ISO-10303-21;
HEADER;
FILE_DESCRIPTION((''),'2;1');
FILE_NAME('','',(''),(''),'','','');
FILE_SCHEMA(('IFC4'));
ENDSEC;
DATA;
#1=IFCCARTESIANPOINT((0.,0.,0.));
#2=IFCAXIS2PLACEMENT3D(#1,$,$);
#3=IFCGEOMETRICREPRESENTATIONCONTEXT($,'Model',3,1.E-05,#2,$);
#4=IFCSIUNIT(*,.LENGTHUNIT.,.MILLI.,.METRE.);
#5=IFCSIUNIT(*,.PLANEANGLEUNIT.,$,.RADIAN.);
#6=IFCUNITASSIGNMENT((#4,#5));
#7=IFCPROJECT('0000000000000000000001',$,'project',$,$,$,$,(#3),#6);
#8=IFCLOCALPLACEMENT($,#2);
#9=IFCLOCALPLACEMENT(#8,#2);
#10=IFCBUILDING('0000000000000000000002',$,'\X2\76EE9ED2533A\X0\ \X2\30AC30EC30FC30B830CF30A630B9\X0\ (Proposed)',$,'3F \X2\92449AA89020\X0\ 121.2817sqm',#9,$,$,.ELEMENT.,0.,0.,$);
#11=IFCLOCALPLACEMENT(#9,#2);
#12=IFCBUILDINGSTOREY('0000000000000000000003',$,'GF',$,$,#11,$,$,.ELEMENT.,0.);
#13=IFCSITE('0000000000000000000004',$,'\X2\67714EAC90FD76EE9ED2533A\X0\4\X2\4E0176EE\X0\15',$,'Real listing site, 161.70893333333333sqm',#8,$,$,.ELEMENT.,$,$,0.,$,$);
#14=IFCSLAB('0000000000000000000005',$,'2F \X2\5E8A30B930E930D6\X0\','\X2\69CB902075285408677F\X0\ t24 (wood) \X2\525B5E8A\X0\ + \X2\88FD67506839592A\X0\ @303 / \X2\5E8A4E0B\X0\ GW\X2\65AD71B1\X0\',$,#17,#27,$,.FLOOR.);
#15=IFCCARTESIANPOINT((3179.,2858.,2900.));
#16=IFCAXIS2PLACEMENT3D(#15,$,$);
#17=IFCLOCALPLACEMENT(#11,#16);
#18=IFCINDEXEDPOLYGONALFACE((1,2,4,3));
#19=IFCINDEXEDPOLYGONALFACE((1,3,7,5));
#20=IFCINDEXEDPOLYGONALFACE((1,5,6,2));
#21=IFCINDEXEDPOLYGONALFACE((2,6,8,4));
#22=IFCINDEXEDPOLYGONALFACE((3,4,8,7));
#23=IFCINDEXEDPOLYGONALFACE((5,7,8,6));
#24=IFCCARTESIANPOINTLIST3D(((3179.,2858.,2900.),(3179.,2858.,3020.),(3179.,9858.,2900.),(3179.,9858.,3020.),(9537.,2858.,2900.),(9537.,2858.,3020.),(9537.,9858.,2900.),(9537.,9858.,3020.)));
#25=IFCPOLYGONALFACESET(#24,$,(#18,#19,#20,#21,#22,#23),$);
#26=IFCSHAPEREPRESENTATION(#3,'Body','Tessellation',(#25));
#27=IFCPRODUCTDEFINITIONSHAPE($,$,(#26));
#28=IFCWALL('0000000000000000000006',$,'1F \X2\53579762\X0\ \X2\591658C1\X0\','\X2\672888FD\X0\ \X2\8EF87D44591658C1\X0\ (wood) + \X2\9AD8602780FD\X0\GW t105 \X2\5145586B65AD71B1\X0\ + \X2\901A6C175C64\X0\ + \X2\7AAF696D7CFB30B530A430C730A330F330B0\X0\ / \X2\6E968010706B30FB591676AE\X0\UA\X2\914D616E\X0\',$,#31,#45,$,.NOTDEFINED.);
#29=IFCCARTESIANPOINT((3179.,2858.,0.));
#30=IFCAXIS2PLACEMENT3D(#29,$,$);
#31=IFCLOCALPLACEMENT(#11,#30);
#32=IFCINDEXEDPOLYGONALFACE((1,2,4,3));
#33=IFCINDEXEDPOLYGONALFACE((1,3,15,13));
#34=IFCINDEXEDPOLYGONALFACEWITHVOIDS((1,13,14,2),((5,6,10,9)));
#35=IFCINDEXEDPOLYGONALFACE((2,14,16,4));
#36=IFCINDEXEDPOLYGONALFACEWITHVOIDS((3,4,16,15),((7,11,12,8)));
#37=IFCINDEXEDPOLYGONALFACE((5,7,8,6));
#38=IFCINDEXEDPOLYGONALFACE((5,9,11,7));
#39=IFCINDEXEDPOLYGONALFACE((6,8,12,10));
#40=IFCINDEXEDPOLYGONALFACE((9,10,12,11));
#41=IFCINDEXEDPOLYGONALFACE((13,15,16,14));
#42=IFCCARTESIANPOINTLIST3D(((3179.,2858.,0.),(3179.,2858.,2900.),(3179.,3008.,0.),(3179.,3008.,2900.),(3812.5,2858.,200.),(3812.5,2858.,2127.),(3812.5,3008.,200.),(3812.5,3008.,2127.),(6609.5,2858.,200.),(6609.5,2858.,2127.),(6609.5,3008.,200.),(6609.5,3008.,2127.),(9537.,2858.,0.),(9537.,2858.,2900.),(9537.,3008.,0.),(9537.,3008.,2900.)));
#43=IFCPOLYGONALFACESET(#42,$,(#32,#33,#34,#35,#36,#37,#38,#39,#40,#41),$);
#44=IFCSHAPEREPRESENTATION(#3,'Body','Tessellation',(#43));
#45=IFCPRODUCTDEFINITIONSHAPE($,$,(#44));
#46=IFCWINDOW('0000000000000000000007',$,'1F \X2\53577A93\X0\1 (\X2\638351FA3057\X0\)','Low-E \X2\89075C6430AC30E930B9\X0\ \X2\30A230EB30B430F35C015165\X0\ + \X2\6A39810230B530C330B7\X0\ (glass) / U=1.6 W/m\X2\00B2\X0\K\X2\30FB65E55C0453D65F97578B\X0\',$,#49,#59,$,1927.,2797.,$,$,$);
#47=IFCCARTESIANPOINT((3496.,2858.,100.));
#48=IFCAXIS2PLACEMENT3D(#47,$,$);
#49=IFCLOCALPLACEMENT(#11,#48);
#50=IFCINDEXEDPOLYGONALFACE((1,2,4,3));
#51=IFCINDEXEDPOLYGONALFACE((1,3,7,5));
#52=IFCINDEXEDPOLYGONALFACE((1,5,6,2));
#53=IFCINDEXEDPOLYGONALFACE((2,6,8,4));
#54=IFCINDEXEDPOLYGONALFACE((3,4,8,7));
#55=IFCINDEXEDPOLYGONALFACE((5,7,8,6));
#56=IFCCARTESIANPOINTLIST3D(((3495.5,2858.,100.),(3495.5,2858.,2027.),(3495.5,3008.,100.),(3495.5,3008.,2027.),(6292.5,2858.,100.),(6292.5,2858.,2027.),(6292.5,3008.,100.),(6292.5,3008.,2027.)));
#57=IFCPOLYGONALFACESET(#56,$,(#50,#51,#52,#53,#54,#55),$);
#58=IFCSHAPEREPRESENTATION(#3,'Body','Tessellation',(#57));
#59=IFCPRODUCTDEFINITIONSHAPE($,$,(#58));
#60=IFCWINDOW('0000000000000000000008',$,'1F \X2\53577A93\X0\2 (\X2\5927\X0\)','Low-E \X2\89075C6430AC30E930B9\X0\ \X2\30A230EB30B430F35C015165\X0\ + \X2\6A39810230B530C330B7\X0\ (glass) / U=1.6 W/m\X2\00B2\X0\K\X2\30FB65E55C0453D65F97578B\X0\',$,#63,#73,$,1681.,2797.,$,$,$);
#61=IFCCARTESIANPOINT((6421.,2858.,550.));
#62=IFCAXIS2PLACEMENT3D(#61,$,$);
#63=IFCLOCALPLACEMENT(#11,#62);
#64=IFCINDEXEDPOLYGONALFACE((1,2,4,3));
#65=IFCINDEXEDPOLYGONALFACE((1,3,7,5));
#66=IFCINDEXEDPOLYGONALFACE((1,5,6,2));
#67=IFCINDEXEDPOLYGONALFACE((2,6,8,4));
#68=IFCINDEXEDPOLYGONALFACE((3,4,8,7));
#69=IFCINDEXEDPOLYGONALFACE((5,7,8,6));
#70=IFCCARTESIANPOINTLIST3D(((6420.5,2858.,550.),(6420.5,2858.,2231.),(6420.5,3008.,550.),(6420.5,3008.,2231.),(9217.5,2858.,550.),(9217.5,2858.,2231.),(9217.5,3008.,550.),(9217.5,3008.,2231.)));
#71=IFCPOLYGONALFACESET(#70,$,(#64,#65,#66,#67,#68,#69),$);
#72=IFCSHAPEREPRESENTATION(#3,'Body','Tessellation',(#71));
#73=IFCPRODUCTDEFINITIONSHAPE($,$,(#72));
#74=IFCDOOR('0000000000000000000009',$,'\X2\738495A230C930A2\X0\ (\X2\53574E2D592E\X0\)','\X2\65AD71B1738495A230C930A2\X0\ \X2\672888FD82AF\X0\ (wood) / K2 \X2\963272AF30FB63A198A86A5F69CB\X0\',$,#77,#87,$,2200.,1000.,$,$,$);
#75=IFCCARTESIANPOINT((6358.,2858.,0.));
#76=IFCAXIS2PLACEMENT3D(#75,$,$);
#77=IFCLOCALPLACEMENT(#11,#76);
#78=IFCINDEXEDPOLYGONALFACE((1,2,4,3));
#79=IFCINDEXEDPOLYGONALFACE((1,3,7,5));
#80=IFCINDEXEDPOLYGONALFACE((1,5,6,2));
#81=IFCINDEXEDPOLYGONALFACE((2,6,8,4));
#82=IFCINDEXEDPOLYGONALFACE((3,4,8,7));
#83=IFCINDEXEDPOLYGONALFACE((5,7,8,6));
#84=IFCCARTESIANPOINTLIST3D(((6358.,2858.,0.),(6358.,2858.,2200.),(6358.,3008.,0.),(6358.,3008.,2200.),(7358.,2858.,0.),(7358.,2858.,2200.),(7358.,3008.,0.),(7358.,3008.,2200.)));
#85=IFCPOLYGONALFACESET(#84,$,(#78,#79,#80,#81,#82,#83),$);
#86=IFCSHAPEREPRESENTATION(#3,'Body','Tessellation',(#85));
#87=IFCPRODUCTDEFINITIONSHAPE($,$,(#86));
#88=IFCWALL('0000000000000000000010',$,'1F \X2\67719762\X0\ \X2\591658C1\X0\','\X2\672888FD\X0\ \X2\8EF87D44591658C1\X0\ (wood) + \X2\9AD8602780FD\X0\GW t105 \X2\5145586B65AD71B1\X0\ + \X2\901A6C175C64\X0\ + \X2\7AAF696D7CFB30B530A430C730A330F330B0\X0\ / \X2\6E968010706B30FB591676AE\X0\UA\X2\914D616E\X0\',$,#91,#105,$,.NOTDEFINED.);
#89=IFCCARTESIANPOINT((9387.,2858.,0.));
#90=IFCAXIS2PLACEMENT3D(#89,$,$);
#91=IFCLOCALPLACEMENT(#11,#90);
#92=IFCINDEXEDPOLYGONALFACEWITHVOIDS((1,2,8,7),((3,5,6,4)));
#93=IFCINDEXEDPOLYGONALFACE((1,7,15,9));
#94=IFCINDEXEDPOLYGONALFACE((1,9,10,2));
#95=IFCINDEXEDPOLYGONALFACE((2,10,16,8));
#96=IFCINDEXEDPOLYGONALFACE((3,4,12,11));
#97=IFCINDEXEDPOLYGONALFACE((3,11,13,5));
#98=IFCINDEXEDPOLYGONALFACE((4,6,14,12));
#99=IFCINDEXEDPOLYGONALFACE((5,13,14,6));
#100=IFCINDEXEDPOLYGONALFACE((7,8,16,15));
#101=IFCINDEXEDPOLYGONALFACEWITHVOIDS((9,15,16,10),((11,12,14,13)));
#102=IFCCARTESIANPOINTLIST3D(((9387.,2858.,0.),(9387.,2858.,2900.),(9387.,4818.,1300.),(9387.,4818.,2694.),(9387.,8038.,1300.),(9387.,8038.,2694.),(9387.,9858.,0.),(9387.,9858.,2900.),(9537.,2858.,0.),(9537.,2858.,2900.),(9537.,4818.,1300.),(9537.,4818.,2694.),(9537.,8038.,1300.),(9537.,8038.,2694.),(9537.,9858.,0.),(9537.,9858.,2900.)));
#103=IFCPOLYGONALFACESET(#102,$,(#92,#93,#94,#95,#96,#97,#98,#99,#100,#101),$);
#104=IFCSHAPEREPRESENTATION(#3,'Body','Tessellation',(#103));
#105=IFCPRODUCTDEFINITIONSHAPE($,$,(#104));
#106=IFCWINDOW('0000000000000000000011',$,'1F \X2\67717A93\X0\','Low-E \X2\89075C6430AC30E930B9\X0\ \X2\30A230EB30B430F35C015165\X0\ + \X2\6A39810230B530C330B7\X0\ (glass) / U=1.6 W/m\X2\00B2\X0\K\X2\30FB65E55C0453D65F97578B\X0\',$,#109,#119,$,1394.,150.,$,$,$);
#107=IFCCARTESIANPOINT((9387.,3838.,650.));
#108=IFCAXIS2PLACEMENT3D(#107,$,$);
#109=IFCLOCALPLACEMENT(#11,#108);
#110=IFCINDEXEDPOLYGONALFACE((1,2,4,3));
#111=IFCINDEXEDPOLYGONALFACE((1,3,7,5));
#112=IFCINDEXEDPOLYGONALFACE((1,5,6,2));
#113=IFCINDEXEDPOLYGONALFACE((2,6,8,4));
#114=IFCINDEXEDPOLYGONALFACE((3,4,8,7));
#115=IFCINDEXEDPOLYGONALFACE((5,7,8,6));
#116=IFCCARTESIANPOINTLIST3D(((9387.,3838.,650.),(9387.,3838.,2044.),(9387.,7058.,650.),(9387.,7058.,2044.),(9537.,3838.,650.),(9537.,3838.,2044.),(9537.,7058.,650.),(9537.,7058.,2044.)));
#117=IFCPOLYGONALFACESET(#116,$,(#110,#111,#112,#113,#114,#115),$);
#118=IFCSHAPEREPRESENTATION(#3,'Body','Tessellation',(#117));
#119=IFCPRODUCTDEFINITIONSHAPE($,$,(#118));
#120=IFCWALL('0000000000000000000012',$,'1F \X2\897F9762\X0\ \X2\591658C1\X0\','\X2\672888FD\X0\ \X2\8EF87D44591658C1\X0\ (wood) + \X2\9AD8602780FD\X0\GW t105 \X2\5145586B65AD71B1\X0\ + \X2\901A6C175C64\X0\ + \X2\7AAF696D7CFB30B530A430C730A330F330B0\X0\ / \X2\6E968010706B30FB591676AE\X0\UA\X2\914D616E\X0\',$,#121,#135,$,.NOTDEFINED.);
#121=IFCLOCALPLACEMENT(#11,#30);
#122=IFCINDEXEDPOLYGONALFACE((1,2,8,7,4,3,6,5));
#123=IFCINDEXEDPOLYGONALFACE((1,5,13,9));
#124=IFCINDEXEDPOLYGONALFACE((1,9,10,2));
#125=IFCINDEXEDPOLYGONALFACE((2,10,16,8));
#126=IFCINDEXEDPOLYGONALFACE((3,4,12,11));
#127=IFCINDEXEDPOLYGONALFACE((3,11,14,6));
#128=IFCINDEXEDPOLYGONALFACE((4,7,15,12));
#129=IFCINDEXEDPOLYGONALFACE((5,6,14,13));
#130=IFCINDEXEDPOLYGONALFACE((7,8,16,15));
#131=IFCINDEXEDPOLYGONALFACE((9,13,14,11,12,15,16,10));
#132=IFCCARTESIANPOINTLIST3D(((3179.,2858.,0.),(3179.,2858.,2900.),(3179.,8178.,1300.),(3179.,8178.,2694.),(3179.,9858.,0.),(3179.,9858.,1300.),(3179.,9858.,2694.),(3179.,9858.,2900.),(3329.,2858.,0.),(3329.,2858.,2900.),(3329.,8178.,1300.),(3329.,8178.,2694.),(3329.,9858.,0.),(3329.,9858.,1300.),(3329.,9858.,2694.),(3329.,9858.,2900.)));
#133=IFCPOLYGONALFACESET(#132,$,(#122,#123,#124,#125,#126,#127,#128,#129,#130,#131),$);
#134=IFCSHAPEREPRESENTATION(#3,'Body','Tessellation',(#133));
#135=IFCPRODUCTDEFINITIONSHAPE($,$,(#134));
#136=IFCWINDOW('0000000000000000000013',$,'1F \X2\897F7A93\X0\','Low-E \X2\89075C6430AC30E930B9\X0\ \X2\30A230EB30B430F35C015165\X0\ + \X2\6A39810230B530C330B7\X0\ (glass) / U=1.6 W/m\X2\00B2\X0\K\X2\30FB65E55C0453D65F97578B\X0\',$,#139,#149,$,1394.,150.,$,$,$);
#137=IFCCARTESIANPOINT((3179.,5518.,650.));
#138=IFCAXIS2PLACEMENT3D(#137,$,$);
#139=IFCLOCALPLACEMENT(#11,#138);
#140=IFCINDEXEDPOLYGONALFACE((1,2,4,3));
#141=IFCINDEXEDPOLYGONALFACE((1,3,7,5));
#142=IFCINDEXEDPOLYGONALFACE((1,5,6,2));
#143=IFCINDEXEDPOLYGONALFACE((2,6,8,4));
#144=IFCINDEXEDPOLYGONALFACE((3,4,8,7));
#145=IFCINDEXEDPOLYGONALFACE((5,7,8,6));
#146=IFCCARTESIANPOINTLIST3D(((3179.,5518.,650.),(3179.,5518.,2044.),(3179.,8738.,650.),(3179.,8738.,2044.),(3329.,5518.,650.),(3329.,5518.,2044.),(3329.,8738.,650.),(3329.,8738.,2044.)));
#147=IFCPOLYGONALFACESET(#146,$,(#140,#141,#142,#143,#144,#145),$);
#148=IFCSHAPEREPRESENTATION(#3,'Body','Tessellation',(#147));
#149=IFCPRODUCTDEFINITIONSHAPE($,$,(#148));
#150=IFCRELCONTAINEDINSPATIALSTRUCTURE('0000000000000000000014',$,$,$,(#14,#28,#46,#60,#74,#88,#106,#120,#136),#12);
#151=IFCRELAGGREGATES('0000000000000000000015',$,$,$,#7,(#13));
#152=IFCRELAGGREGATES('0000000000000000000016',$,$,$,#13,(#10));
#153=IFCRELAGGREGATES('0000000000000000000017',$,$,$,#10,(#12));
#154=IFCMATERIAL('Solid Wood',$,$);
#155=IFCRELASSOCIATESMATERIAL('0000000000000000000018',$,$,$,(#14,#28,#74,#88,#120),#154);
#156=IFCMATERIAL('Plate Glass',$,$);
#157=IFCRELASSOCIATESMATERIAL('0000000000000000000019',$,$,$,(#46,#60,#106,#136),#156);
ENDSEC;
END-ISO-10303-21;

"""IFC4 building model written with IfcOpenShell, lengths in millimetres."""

from ifc_helpers import new_model, si_unit, frame, frame_2d, origin, place, context, project, spatial, rectangle, extrude, material, element, fill, save


model = new_model("IFC4")

# Units and contexts
model_context = context("Model", 3, precision=1e-05, world=origin())
ifc_project = project(units=[si_unit("LENGTHUNIT", "METRE", prefix="MILLI"), si_unit("PLANEANGLEUNIT", "RADIAN")], contexts=[model_context])

# Site, building, storey
site_placement = place(None, origin())
site = spatial("IfcSite", under=ifc_project, at=site_placement, Name="東京都目黒区4丁目15", ObjectType="Real listing site, 161.70893333333333sqm", CompositionType="ELEMENT", RefElevation=0.0)
building_placement = place(site_placement, origin())
building = spatial("IfcBuilding", under=site, at=building_placement, Name="目黒区 ガレージハウス (Proposed)", ObjectType="3F 鉄骨造 121.2817sqm", CompositionType="ELEMENT", ElevationOfRefHeight=0.0, ElevationOfTerrain=0.0)
storey_placement = place(building_placement, origin())
storey = spatial("IfcBuildingStorey", under=building, at=storey_placement, Name="GF", CompositionType="ELEMENT", Elevation=0.0)

# Slab
ifc_material_1 = material(Name="Solid Wood")
slab_1_placement = place(storey_placement, frame((3179.0, 2858.0, 2900.0)))
element("IfcSlab", 1, at=slab_1_placement, inside=storey, material=ifc_material_1, Name="2F 床スラブ", Description="構造用合板 t24 (wood) 剛床 + 製材根太 @303 / 床下 GW断熱", PredefinedType="FLOOR", context=model_context, shape_type="SweptSolid", body=[
    extrude(rectangle(XDim=6358.0, YDim=7000.0, at=frame_2d((3179.0, 3500.0))), frame((3179.0, 2858.0, 2900.0)), (0.0, 0.0, 1.0), 120.0),
])

# Wall, openings, windows, door
wall_1_placement = place(storey_placement, frame((3179.0, 2858.0, 0.0)))
wall_1 = element("IfcWall", 2, at=wall_1_placement, inside=storey, material=ifc_material_1, Name="1F 南面 外壁", Description="木製 軸組外壁 (wood) + 高性能GW t105 充填断熱 + 通気層 + 窯業系サイディング / 準耐火・外皮UA配慮", PredefinedType="NOTDEFINED", context=model_context, shape_type="SweptSolid", body=[
    extrude(rectangle(XDim=6358.0, YDim=150.0, at=frame_2d((3179.0, 75.0))), frame((3179.0, 2858.0, 0.0)), (0.0, 0.0, 1.0), 2900.0),
])
opening_1_placement = place(storey_placement, frame((3496.0, 2858.0, 100.0)))
opening_1 = element("IfcOpeningElement", 3, at=opening_1_placement, cuts=wall_1, PredefinedType="NOTDEFINED", context=model_context, shape_type="SweptSolid", body=[
    extrude(rectangle(XDim=2797.0, YDim=150.0, at=frame_2d((1398.0, 75.0))), frame((3496.0, 2858.0, 100.0)), (0.0, 0.0, 1.0), 1927.0),
])
opening_2_placement = place(storey_placement, frame((6421.0, 2858.0, 550.0)))
opening_2 = element("IfcOpeningElement", 4, at=opening_2_placement, cuts=wall_1, PredefinedType="NOTDEFINED", context=model_context, shape_type="SweptSolid", body=[
    extrude(rectangle(XDim=2797.0, YDim=150.0, at=frame_2d((1398.0, 75.0))), frame((6421.0, 2858.0, 550.0)), (0.0, 0.0, 1.0), 1681.0),
])
opening_3_placement = place(storey_placement, frame((6358.0, 2858.0, 0.0)))
opening_3 = element("IfcOpeningElement", 5, at=opening_3_placement, cuts=wall_1, PredefinedType="NOTDEFINED", context=model_context, shape_type="SweptSolid", body=[
    extrude(rectangle(XDim=1000.0, YDim=150.0, at=frame_2d((500.0, 75.0))), frame((6358.0, 2858.0, 0.0)), (0.0, 0.0, 1.0), 2200.0),
])
ifc_material_2 = material(Name="Plate Glass")
window_1_placement = place(storey_placement, frame((3496.0, 2858.0, 100.0)))
window_1 = element("IfcWindow", 6, at=window_1_placement, inside=storey, material=ifc_material_2, Name="1F 南窓1 (掃出し)", Description="Low-E 複層ガラス アルゴン封入 + 樹脂サッシ (glass) / U=1.6 W/m²K・日射取得型", OverallHeight=1927.0, OverallWidth=2797.0, context=model_context, shape_type="SweptSolid", body=[
    extrude(rectangle(XDim=2797.0, YDim=150.0, at=frame_2d((1398.0, 75.0))), frame((3496.0, 2858.0, 100.0)), (0.0, 0.0, 1.0), 1927.0),
])
fill(opening_1, window_1)
window_2_placement = place(storey_placement, frame((6421.0, 2858.0, 550.0)))
window_2 = element("IfcWindow", 7, at=window_2_placement, inside=storey, material=ifc_material_2, Name="1F 南窓2 (大)", Description="Low-E 複層ガラス アルゴン封入 + 樹脂サッシ (glass) / U=1.6 W/m²K・日射取得型", OverallHeight=1681.0, OverallWidth=2797.0, context=model_context, shape_type="SweptSolid", body=[
    extrude(rectangle(XDim=2797.0, YDim=150.0, at=frame_2d((1398.0, 75.0))), frame((6421.0, 2858.0, 550.0)), (0.0, 0.0, 1.0), 1681.0),
])
fill(opening_2, window_2)
door_placement = place(storey_placement, frame((6358.0, 2858.0, 0.0)))
door = element("IfcDoor", 8, at=door_placement, inside=storey, material=ifc_material_1, Name="玄関ドア (南中央)", Description="断熱玄関ドア 木製芯 (wood) / K2 防犯・採風機構", OverallHeight=2200.0, OverallWidth=1000.0, context=model_context, shape_type="SweptSolid", body=[
    extrude(rectangle(XDim=1000.0, YDim=150.0, at=frame_2d((500.0, 75.0))), frame((6358.0, 2858.0, 0.0)), (0.0, 0.0, 1.0), 2200.0),
])
fill(opening_3, door)

# Walls, openings, windows
wall_2_placement = place(storey_placement, frame((9387.0, 2858.0, 0.0)))
wall_2 = element("IfcWall", 9, at=wall_2_placement, inside=storey, material=ifc_material_1, Name="1F 東面 外壁", Description="木製 軸組外壁 (wood) + 高性能GW t105 充填断熱 + 通気層 + 窯業系サイディング / 準耐火・外皮UA配慮", PredefinedType="NOTDEFINED", context=model_context, shape_type="SweptSolid", body=[
    extrude(rectangle(XDim=150.0, YDim=7000.0, at=frame_2d((75.0, 3500.0))), frame((9387.0, 2858.0, 0.0)), (0.0, 0.0, 1.0), 2900.0),
])
opening_4_placement = place(storey_placement, frame((9387.0, 3838.0, 650.0)))
opening_4 = element("IfcOpeningElement", 10, at=opening_4_placement, cuts=wall_2, PredefinedType="NOTDEFINED", context=model_context, shape_type="SweptSolid", body=[
    extrude(rectangle(XDim=150.0, YDim=3220.0, at=frame_2d((75.0, 1610.0))), frame((9387.0, 3838.0, 650.0)), (0.0, 0.0, 1.0), 1394.0),
])
window_3_placement = place(storey_placement, frame((9387.0, 3838.0, 650.0)))
window_3 = element("IfcWindow", 11, at=window_3_placement, inside=storey, material=ifc_material_2, Name="1F 東窓", Description="Low-E 複層ガラス アルゴン封入 + 樹脂サッシ (glass) / U=1.6 W/m²K・日射取得型", OverallHeight=1394.0, OverallWidth=150.0, context=model_context, shape_type="SweptSolid", body=[
    extrude(rectangle(XDim=150.0, YDim=3220.0, at=frame_2d((75.0, 1610.0))), frame((9387.0, 3838.0, 650.0)), (0.0, 0.0, 1.0), 1394.0),
])
fill(opening_4, window_3)
wall_3_placement = place(storey_placement, frame((3179.0, 2858.0, 0.0)))
wall_3 = element("IfcWall", 12, at=wall_3_placement, inside=storey, material=ifc_material_1, Name="1F 西面 外壁", Description="木製 軸組外壁 (wood) + 高性能GW t105 充填断熱 + 通気層 + 窯業系サイディング / 準耐火・外皮UA配慮", PredefinedType="NOTDEFINED", context=model_context, shape_type="SweptSolid", body=[
    extrude(rectangle(XDim=150.0, YDim=7000.0, at=frame_2d((75.0, 3500.0))), frame((3179.0, 2858.0, 0.0)), (0.0, 0.0, 1.0), 2900.0),
])
opening_5_placement = place(storey_placement, frame((3179.0, 5518.0, 650.0)))
opening_5 = element("IfcOpeningElement", 13, at=opening_5_placement, cuts=wall_3, PredefinedType="NOTDEFINED", context=model_context, shape_type="SweptSolid", body=[
    extrude(rectangle(XDim=150.0, YDim=3220.0, at=frame_2d((75.0, 1610.0))), frame((3179.0, 5518.0, 650.0)), (0.0, 0.0, 1.0), 1394.0),
])
window_4_placement = place(storey_placement, frame((3179.0, 5518.0, 650.0)))
window_4 = element("IfcWindow", 14, at=window_4_placement, inside=storey, material=ifc_material_2, Name="1F 西窓", Description="Low-E 複層ガラス アルゴン封入 + 樹脂サッシ (glass) / U=1.6 W/m²K・日射取得型", OverallHeight=1394.0, OverallWidth=150.0, context=model_context, shape_type="SweptSolid", body=[
    extrude(rectangle(XDim=150.0, YDim=3220.0, at=frame_2d((75.0, 1610.0))), frame((3179.0, 5518.0, 650.0)), (0.0, 0.0, 1.0), 1394.0),
])
fill(opening_5, window_4)

save(model, "model.ifc")
